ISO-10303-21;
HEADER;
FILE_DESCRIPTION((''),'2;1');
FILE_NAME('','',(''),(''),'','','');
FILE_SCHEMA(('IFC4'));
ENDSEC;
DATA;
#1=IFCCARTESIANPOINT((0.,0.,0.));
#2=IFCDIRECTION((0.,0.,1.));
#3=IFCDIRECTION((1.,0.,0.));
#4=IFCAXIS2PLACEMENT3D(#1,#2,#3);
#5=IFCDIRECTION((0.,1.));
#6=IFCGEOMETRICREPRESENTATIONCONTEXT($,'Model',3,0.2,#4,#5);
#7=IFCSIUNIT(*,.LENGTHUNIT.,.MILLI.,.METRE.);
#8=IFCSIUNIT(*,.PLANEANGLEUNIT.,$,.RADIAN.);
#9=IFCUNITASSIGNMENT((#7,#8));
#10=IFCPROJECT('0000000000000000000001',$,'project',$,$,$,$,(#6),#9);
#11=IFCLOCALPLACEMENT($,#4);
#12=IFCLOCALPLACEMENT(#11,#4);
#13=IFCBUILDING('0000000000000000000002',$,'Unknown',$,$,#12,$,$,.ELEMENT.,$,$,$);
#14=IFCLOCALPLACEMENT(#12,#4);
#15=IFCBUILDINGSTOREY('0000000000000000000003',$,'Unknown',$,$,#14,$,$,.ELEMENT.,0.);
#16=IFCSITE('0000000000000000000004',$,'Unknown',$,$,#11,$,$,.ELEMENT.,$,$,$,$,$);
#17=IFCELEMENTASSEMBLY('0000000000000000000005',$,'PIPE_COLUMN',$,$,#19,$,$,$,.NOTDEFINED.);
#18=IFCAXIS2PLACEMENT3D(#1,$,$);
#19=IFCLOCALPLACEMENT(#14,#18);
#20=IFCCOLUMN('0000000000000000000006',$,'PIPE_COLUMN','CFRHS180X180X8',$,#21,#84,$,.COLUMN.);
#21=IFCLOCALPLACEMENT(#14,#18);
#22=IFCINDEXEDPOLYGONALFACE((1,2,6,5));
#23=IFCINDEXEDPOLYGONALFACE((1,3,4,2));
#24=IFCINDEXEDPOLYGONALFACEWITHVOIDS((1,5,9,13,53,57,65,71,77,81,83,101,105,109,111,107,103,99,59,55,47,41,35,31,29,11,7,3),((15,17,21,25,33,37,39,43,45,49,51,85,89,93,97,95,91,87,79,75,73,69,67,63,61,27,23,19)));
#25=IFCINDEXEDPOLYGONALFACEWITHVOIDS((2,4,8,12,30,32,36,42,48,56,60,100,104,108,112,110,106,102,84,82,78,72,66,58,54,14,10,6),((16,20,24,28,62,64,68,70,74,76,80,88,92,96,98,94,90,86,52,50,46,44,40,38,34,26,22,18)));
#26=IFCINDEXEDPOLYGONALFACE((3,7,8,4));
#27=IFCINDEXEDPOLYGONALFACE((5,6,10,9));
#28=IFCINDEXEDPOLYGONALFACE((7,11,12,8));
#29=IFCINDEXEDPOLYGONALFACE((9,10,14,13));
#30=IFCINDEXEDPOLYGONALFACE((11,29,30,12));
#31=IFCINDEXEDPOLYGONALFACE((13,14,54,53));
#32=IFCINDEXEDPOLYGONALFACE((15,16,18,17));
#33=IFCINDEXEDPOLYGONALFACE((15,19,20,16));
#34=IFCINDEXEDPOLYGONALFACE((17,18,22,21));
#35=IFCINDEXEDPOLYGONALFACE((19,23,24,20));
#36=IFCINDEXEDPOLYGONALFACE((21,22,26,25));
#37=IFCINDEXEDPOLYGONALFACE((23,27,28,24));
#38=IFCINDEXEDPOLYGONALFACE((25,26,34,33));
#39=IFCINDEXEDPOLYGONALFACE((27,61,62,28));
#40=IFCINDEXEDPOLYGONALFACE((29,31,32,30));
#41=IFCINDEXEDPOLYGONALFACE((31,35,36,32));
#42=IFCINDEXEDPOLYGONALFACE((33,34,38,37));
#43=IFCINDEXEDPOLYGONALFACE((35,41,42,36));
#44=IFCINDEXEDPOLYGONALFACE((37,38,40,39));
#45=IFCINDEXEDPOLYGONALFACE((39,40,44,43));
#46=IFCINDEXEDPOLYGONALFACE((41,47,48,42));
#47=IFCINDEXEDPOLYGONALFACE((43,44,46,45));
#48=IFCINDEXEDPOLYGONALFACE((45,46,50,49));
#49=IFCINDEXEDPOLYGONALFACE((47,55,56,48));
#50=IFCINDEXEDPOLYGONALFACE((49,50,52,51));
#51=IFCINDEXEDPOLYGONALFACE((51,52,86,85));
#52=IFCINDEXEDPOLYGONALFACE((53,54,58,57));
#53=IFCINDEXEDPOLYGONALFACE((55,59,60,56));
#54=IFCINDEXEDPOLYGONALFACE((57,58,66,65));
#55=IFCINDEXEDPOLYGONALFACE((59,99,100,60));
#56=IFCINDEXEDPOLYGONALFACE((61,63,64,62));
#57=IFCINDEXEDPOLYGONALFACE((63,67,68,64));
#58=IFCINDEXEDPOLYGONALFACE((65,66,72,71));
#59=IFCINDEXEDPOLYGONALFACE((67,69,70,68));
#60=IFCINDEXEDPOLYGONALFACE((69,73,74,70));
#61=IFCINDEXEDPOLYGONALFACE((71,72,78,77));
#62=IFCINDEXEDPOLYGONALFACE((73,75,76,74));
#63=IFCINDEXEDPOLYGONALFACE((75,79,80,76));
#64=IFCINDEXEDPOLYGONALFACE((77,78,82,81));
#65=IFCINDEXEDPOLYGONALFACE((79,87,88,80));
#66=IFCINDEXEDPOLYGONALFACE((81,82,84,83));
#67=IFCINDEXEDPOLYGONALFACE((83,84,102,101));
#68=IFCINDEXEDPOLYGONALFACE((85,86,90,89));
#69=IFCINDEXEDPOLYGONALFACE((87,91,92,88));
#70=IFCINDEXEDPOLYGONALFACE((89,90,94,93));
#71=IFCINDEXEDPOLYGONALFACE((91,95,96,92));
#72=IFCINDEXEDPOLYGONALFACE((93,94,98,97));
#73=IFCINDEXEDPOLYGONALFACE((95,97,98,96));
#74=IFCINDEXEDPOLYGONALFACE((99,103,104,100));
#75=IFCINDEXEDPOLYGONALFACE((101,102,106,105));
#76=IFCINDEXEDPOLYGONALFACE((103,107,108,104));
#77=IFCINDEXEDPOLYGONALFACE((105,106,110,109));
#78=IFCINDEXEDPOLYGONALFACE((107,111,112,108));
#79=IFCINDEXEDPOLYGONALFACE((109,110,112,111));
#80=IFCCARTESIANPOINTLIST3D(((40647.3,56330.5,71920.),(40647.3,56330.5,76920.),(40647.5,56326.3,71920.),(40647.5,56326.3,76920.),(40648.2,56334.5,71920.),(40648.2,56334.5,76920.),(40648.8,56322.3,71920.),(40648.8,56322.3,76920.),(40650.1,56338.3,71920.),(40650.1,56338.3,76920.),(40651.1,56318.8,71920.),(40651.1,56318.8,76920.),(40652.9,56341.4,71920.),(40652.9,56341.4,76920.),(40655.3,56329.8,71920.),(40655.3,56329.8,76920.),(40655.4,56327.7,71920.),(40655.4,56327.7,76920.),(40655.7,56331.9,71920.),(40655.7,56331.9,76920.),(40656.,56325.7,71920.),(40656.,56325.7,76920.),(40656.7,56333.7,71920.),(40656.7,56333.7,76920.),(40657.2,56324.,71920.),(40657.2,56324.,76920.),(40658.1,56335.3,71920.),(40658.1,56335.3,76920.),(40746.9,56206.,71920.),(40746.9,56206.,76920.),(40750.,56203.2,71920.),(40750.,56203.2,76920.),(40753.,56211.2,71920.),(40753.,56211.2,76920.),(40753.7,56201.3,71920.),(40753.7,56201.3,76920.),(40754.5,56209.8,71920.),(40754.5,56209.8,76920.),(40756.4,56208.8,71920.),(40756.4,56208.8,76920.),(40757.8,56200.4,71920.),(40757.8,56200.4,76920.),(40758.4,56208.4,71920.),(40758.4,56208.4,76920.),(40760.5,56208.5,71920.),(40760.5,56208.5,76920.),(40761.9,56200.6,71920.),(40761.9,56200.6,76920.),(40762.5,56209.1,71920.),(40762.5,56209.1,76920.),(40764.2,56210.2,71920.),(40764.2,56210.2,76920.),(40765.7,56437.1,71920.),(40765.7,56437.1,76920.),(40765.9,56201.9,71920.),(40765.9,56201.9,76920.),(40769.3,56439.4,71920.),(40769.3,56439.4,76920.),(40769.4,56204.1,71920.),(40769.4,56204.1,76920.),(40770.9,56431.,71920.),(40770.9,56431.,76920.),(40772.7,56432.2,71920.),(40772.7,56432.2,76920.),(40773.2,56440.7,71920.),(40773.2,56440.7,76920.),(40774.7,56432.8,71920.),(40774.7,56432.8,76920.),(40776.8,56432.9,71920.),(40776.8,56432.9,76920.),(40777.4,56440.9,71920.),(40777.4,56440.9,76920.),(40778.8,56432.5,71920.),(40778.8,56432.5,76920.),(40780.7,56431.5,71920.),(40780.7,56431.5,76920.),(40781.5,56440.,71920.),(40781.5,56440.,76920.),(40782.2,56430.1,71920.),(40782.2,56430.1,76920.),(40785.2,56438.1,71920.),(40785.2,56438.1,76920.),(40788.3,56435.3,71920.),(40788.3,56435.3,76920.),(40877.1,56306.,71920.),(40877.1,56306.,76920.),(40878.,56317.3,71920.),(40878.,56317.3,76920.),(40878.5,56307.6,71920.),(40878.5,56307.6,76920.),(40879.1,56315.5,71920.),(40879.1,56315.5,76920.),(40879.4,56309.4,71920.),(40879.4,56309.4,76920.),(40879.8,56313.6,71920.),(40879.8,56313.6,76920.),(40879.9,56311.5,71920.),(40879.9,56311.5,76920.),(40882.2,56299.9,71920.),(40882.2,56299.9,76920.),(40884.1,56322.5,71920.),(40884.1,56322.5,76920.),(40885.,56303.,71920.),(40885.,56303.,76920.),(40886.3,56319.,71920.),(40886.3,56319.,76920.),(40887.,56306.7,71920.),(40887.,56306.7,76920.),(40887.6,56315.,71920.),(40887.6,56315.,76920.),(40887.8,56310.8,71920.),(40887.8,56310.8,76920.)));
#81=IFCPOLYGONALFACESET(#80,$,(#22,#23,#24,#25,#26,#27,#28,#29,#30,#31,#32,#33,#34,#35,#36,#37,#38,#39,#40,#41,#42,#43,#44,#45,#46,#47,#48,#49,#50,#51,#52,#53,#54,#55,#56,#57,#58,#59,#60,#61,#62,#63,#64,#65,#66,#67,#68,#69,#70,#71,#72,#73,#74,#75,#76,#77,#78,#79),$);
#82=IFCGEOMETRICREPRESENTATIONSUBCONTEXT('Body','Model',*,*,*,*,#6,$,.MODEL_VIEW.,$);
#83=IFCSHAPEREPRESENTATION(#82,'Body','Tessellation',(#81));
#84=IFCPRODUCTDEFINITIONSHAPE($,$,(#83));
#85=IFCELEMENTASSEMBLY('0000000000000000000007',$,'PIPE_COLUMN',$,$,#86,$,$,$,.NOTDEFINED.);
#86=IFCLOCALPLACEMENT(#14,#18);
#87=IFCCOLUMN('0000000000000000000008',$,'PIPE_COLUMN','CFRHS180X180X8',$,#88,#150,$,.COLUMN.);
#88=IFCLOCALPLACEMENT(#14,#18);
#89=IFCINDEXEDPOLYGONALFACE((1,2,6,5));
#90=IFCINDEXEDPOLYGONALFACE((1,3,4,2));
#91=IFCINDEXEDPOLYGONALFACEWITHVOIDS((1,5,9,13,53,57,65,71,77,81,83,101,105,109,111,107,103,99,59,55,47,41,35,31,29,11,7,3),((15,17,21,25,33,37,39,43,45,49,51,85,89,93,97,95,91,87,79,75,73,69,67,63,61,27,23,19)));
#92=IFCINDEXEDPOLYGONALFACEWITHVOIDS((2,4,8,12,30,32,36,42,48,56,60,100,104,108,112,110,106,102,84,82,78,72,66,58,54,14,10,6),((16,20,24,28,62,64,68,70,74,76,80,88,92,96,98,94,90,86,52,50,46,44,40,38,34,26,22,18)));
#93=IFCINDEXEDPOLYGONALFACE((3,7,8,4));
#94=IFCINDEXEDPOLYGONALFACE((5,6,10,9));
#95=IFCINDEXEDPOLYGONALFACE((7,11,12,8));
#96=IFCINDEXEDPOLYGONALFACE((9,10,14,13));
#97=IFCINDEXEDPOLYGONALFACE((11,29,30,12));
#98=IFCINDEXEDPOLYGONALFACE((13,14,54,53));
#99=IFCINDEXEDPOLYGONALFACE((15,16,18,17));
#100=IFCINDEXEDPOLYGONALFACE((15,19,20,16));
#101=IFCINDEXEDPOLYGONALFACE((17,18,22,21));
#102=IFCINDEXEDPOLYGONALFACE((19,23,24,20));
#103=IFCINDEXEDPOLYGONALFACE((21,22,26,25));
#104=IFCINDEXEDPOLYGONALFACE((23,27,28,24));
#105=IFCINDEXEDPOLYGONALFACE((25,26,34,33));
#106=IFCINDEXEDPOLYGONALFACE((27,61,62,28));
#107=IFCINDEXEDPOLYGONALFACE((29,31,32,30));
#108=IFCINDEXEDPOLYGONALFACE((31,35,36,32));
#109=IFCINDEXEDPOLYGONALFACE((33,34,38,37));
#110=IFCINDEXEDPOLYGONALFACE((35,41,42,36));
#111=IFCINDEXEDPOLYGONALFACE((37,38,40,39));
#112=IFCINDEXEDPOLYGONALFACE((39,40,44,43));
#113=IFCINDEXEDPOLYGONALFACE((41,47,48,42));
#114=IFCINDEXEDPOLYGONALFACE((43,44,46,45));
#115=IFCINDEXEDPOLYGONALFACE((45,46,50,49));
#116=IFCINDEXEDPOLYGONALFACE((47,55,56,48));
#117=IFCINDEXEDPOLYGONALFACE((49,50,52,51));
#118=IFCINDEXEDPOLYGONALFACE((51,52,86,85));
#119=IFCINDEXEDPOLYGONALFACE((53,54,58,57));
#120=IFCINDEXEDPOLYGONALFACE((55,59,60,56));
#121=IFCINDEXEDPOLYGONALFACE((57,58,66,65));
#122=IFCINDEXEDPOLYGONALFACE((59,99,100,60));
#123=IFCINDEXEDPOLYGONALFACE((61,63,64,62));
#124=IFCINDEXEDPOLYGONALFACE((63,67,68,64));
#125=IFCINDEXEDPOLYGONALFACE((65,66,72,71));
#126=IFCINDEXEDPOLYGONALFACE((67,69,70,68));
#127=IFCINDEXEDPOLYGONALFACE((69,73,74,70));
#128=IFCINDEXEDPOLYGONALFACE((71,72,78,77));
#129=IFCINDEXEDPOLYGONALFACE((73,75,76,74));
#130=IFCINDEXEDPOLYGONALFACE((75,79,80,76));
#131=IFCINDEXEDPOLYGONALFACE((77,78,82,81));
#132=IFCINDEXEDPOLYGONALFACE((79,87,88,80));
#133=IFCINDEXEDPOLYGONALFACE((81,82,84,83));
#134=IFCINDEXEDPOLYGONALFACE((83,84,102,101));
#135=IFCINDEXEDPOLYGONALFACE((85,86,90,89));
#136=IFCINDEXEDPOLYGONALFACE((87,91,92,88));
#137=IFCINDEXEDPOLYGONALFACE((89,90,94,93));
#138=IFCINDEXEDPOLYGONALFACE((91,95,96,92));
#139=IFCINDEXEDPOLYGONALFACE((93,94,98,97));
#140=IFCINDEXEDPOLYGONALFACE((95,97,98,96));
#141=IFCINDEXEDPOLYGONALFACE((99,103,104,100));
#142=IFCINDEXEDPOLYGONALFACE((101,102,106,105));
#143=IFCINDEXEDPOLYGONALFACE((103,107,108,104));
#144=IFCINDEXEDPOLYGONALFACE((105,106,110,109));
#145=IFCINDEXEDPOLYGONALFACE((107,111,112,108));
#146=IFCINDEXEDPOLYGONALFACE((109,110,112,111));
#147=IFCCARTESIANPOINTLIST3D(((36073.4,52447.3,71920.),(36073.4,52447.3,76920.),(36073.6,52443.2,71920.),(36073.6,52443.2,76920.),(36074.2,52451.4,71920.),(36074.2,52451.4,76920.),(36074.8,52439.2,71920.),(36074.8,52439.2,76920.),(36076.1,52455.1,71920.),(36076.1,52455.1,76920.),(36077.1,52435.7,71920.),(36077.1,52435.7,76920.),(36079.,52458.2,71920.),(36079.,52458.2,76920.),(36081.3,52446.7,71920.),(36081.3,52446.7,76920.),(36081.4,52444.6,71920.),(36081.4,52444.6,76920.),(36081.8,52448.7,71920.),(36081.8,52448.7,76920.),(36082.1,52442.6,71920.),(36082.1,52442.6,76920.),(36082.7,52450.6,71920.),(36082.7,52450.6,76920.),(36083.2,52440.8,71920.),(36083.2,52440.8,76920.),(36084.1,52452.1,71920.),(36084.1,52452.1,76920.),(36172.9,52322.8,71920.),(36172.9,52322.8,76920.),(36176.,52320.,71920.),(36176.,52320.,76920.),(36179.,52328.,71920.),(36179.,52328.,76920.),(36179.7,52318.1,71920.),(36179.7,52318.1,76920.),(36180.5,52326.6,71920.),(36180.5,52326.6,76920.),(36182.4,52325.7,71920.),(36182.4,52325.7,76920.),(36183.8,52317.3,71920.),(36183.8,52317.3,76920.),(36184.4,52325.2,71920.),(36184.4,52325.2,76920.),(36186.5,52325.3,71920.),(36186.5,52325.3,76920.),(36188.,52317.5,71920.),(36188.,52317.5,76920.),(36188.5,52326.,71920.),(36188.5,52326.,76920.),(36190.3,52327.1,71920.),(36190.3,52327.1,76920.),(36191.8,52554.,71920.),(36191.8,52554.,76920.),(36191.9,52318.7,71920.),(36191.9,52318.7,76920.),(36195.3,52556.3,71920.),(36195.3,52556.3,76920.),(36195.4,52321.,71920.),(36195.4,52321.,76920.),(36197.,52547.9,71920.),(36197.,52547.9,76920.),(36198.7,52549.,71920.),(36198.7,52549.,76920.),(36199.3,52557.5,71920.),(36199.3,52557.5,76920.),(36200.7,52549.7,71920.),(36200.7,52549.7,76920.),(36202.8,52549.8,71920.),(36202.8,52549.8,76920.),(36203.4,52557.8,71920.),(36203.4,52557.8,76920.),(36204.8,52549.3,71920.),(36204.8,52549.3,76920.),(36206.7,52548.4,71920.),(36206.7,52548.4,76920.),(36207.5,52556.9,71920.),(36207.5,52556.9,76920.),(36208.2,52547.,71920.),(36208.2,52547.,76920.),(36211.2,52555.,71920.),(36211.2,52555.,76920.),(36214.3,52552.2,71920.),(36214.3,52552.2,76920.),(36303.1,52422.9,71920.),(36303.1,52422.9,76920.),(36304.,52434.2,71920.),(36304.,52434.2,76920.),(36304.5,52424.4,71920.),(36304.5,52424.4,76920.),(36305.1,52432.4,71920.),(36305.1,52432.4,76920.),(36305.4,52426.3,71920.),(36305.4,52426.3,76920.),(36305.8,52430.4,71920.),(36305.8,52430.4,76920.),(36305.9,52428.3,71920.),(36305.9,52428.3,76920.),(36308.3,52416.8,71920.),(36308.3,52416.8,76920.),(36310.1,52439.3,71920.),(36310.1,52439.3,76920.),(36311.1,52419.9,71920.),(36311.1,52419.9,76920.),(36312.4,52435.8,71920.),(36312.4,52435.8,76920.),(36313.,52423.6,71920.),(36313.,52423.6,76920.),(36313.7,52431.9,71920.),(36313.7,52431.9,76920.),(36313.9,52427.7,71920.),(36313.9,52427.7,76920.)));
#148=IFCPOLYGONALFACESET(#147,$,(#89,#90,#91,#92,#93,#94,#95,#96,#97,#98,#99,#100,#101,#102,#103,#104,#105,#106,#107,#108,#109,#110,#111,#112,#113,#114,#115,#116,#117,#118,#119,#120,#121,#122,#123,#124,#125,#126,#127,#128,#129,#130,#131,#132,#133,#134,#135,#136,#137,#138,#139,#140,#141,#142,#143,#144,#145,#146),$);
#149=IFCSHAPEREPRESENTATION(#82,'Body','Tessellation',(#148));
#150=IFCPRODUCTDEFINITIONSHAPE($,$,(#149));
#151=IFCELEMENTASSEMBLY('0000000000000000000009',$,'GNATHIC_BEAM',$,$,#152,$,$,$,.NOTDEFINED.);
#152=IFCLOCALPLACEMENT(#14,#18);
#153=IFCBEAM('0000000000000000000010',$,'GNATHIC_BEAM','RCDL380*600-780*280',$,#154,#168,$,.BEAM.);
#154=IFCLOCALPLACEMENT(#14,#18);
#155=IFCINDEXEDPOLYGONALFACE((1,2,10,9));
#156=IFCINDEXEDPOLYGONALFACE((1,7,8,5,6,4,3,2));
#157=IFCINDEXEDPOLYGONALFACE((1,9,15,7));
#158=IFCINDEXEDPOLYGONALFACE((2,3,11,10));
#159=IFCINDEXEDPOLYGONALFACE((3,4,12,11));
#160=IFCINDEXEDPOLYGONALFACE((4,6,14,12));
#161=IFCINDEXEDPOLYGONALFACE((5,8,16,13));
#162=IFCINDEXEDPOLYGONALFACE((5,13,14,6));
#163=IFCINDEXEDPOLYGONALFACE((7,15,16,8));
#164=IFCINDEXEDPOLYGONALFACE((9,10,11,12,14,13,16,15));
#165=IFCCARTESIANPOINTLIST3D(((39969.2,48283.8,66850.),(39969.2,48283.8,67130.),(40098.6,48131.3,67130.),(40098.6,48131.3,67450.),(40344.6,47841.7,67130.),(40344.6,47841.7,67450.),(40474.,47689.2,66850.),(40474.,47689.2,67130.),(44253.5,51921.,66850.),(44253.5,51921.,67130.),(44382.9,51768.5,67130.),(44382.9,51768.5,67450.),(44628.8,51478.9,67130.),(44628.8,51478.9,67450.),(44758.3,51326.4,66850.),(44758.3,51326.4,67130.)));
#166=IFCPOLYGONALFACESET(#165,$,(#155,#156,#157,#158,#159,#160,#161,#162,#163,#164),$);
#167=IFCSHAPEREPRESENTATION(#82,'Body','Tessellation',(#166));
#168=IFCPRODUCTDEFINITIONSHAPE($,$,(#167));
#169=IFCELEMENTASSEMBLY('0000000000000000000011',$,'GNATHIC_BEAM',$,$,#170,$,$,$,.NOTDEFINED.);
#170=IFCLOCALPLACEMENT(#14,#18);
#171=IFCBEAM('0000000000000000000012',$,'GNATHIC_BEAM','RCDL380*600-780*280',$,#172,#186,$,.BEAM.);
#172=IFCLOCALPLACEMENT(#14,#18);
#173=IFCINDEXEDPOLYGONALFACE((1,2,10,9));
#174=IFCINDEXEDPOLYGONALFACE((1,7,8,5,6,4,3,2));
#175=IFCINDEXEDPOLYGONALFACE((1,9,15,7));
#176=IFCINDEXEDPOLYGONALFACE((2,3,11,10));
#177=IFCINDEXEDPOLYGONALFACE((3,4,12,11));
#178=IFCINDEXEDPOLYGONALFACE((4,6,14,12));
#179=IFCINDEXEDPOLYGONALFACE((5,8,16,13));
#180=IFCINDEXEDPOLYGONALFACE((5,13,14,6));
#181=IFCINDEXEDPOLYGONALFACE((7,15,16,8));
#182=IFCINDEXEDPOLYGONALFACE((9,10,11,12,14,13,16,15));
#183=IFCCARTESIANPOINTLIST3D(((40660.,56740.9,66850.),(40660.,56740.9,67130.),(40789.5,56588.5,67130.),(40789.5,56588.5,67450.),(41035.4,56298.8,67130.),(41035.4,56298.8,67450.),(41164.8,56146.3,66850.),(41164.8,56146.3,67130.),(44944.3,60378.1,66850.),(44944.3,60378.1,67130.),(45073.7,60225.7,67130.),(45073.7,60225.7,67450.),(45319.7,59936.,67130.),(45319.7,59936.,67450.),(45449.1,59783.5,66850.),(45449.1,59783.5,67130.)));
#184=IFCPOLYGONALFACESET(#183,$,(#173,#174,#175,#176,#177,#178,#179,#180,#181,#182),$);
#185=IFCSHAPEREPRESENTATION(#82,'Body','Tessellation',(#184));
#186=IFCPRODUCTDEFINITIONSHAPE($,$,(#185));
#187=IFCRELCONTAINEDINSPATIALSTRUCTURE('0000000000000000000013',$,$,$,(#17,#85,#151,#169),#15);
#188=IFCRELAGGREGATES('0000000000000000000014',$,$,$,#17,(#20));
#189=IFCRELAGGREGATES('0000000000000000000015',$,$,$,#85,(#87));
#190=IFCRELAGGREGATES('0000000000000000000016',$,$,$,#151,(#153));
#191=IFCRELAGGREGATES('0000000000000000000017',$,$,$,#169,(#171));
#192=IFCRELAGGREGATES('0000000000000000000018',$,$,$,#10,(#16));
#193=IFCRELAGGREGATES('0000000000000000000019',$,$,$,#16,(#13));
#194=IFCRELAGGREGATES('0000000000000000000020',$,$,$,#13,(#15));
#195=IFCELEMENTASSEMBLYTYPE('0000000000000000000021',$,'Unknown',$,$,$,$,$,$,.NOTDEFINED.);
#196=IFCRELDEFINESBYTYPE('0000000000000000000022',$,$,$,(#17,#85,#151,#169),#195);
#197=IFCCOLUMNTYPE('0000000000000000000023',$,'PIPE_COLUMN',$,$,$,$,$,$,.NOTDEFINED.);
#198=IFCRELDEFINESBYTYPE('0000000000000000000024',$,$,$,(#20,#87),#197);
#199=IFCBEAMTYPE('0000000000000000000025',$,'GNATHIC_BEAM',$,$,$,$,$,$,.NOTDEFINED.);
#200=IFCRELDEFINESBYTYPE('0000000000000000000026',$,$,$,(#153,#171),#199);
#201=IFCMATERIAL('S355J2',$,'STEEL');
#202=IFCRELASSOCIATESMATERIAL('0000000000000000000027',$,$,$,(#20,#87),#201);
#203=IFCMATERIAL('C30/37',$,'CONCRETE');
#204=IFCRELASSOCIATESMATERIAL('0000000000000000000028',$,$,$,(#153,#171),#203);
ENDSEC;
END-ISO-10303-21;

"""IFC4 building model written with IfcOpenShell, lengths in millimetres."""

from ifc_helpers import new_model, si_unit, direction, frame, origin_with_axes, origin_2d_with_axis, place, context, subcontext, project, spatial, polyline, hollow_rectangle, outline, extrude, material, material_profile, profile_set, profile_usage, type_object, element, aggregate, save


model = new_model("IFC4")

# Units and contexts
model_context = context("Model", 3, precision=0.2, world=origin_with_axes(), true_north=direction((0.0, 1.0)))
body_context = subcontext(model_context, "Body", "Model", "MODEL_VIEW")
ifc_project = project(units=[si_unit("LENGTHUNIT", "METRE", prefix="MILLI"), si_unit("PLANEANGLEUNIT", "RADIAN")], contexts=[model_context])

# Site, building, storey
site_placement = place(None, origin_with_axes())
site = spatial("IfcSite", under=ifc_project, at=site_placement, Name="Unknown", CompositionType="ELEMENT")
building_placement = place(site_placement, origin_with_axes())
building = spatial("IfcBuilding", under=site, at=building_placement, Name="Unknown", CompositionType="ELEMENT")
storey_placement = place(building_placement, origin_with_axes())
storey = spatial("IfcBuildingStorey", under=building, at=storey_placement, Name="Unknown", CompositionType="ELEMENT", Elevation=0.0)

# Element assemblies, columns
element_assembly_type = type_object("IfcElementAssemblyType", Name="Unknown", PredefinedType="NOTDEFINED")
ifc_material_1 = material(Name="S355J2", Category="STEEL")
ifc_material_profile_1 = material_profile(ifc_material_1, hollow_rectangle(XDim=180.0, YDim=180.0, WallThickness=8.0, InnerFilletRadius=8.0, OuterFilletRadius=16.0, at=origin_2d_with_axis()), Name="CFRHS180X180X8")
ifc_profile_set_1 = profile_set([ifc_material_profile_1])
column_type_1 = type_object("IfcColumnType", Name="PIPE_COLUMN")
assembly_1_placement = place(storey_placement, frame((40767.6, 56320.6, 71920.0), z_axis=(-0.762329, -0.64719, 0.0), x_axis=(0.0, 0.0, 1.0)))
assembly_1 = element("IfcElementAssembly", 1, at=assembly_1_placement, inside=storey, type_object=element_assembly_type, Name="PIPE_COLUMN", PredefinedType="NOTDEFINED")
ifc_profile_usage_1 = profile_usage(ifc_profile_set_1, cardinal=5)
column_1_placement = place(assembly_1_placement, origin_with_axes())
column_1 = element("IfcColumn", 2, at=column_1_placement, type_object=column_type_1, material=ifc_profile_usage_1, Name="PIPE_COLUMN", Description="CFRHS180X180X8", PredefinedType="COLUMN", context=body_context, shape_type="SolidModel", body=[
    extrude(hollow_rectangle(XDim=180.0, YDim=180.0, WallThickness=8.0, InnerFilletRadius=8.0, OuterFilletRadius=16.0, at=origin_2d_with_axis()), frame((0.0, 0.0, 0.0), z_axis=(-1.0, 0.0, 0.0), x_axis=(0.0, 0.0, 1.0)), (0.0, 0.0, -1.0), 5000.0),
])
aggregate(assembly_1, [column_1])
assembly_2_placement = place(storey_placement, frame((36193.6, 52437.5, 71920.0), z_axis=(-0.762329, -0.64719, 0.0), x_axis=(0.0, 0.0, 1.0)))
assembly_2 = element("IfcElementAssembly", 3, at=assembly_2_placement, inside=storey, type_object=element_assembly_type, Name="PIPE_COLUMN", PredefinedType="NOTDEFINED")
column_2_placement = place(assembly_2_placement, origin_with_axes())
column_2 = element("IfcColumn", 4, at=column_2_placement, type_object=column_type_1, material=ifc_profile_usage_1, Name="PIPE_COLUMN", Description="CFRHS180X180X8", PredefinedType="COLUMN", context=body_context, shape_type="SolidModel", body=[
    extrude(hollow_rectangle(XDim=180.0, YDim=180.0, WallThickness=8.0, InnerFilletRadius=8.0, OuterFilletRadius=16.0, at=origin_2d_with_axis()), frame((0.0, 0.0, 0.0), z_axis=(-1.0, 0.0, 0.0), x_axis=(0.0, 0.0, 1.0)), (0.0, 0.0, -1.0), 5000.0),
])
aggregate(assembly_2, [column_2])

# Element assemblies, beams
assembly_3_placement = place(storey_placement, frame((40221.6, 47986.5, 67150.0), z_axis=(0.64719, -0.762329, 0.0), x_axis=(0.762329, 0.64719, 0.0)))
assembly_3 = element("IfcElementAssembly", 5, at=assembly_3_placement, inside=storey, type_object=element_assembly_type, Name="GNATHIC_BEAM", PredefinedType="NOTDEFINED")
ifc_material_2 = material(Name="C30/37", Category="CONCRETE")
ifc_material_profile_2 = material_profile(ifc_material_2, outline(polyline([(-390.0, -300.0), (390.0, -300.0), (390.0, -20.0), (190.0, -20.0), (190.0, 300.0), (-190.0, 300.0), (-190.0, -20.0), (-390.0, -20.0), (-390.0, -300.0)])), Name="RCDL380*600-780*280")
ifc_profile_set_2 = profile_set([ifc_material_profile_2])
ifc_profile_usage_2 = profile_usage(ifc_profile_set_2, cardinal=2)
beam_type_1 = type_object("IfcBeamType", Name="GNATHIC_BEAM")
beam_1_placement = place(assembly_3_placement, origin_with_axes())
beam_1 = element("IfcBeam", 6, at=beam_1_placement, type_object=beam_type_1, material=ifc_profile_usage_2, Name="GNATHIC_BEAM", Description="RCDL380*600-780*280", PredefinedType="BEAM", context=body_context, shape_type="SolidModel", body=[
    extrude(outline(polyline([(-390.0, -300.0), (390.0, -300.0), (390.0, -20.0), (190.0, -20.0), (190.0, 300.0), (-190.0, 300.0), (-190.0, -20.0), (-390.0, -20.0), (-390.0, -300.0)])), frame((0.0, 0.0, 0.0), z_axis=(-1.0, 0.0, 0.0), x_axis=(0.0, 0.0, 1.0)), (0.0, 0.0, -1.0), 5620.0),
])
aggregate(assembly_3, [beam_1])
assembly_4_placement = place(storey_placement, frame((40912.4, 56443.6, 67150.0), z_axis=(0.64719, -0.762329, 0.0), x_axis=(0.762329, 0.64719, 0.0)))
assembly_4 = element("IfcElementAssembly", 7, at=assembly_4_placement, inside=storey, type_object=element_assembly_type, Name="GNATHIC_BEAM", PredefinedType="NOTDEFINED")
beam_2_placement = place(assembly_4_placement, origin_with_axes())
beam_2 = element("IfcBeam", 8, at=beam_2_placement, type_object=beam_type_1, material=ifc_profile_usage_2, Name="GNATHIC_BEAM", Description="RCDL380*600-780*280", PredefinedType="BEAM", context=body_context, shape_type="SolidModel", body=[
    extrude(outline(polyline([(-390.0, -300.0), (390.0, -300.0), (390.0, -20.0), (190.0, -20.0), (190.0, 300.0), (-190.0, 300.0), (-190.0, -20.0), (-390.0, -20.0), (-390.0, -300.0)])), frame((0.0, 0.0, 0.0), z_axis=(-1.0, 0.0, 0.0), x_axis=(0.0, 0.0, 1.0)), (0.0, 0.0, -1.0), 5620.0),
])
aggregate(assembly_4, [beam_2])

save(model, "model.ifc")
